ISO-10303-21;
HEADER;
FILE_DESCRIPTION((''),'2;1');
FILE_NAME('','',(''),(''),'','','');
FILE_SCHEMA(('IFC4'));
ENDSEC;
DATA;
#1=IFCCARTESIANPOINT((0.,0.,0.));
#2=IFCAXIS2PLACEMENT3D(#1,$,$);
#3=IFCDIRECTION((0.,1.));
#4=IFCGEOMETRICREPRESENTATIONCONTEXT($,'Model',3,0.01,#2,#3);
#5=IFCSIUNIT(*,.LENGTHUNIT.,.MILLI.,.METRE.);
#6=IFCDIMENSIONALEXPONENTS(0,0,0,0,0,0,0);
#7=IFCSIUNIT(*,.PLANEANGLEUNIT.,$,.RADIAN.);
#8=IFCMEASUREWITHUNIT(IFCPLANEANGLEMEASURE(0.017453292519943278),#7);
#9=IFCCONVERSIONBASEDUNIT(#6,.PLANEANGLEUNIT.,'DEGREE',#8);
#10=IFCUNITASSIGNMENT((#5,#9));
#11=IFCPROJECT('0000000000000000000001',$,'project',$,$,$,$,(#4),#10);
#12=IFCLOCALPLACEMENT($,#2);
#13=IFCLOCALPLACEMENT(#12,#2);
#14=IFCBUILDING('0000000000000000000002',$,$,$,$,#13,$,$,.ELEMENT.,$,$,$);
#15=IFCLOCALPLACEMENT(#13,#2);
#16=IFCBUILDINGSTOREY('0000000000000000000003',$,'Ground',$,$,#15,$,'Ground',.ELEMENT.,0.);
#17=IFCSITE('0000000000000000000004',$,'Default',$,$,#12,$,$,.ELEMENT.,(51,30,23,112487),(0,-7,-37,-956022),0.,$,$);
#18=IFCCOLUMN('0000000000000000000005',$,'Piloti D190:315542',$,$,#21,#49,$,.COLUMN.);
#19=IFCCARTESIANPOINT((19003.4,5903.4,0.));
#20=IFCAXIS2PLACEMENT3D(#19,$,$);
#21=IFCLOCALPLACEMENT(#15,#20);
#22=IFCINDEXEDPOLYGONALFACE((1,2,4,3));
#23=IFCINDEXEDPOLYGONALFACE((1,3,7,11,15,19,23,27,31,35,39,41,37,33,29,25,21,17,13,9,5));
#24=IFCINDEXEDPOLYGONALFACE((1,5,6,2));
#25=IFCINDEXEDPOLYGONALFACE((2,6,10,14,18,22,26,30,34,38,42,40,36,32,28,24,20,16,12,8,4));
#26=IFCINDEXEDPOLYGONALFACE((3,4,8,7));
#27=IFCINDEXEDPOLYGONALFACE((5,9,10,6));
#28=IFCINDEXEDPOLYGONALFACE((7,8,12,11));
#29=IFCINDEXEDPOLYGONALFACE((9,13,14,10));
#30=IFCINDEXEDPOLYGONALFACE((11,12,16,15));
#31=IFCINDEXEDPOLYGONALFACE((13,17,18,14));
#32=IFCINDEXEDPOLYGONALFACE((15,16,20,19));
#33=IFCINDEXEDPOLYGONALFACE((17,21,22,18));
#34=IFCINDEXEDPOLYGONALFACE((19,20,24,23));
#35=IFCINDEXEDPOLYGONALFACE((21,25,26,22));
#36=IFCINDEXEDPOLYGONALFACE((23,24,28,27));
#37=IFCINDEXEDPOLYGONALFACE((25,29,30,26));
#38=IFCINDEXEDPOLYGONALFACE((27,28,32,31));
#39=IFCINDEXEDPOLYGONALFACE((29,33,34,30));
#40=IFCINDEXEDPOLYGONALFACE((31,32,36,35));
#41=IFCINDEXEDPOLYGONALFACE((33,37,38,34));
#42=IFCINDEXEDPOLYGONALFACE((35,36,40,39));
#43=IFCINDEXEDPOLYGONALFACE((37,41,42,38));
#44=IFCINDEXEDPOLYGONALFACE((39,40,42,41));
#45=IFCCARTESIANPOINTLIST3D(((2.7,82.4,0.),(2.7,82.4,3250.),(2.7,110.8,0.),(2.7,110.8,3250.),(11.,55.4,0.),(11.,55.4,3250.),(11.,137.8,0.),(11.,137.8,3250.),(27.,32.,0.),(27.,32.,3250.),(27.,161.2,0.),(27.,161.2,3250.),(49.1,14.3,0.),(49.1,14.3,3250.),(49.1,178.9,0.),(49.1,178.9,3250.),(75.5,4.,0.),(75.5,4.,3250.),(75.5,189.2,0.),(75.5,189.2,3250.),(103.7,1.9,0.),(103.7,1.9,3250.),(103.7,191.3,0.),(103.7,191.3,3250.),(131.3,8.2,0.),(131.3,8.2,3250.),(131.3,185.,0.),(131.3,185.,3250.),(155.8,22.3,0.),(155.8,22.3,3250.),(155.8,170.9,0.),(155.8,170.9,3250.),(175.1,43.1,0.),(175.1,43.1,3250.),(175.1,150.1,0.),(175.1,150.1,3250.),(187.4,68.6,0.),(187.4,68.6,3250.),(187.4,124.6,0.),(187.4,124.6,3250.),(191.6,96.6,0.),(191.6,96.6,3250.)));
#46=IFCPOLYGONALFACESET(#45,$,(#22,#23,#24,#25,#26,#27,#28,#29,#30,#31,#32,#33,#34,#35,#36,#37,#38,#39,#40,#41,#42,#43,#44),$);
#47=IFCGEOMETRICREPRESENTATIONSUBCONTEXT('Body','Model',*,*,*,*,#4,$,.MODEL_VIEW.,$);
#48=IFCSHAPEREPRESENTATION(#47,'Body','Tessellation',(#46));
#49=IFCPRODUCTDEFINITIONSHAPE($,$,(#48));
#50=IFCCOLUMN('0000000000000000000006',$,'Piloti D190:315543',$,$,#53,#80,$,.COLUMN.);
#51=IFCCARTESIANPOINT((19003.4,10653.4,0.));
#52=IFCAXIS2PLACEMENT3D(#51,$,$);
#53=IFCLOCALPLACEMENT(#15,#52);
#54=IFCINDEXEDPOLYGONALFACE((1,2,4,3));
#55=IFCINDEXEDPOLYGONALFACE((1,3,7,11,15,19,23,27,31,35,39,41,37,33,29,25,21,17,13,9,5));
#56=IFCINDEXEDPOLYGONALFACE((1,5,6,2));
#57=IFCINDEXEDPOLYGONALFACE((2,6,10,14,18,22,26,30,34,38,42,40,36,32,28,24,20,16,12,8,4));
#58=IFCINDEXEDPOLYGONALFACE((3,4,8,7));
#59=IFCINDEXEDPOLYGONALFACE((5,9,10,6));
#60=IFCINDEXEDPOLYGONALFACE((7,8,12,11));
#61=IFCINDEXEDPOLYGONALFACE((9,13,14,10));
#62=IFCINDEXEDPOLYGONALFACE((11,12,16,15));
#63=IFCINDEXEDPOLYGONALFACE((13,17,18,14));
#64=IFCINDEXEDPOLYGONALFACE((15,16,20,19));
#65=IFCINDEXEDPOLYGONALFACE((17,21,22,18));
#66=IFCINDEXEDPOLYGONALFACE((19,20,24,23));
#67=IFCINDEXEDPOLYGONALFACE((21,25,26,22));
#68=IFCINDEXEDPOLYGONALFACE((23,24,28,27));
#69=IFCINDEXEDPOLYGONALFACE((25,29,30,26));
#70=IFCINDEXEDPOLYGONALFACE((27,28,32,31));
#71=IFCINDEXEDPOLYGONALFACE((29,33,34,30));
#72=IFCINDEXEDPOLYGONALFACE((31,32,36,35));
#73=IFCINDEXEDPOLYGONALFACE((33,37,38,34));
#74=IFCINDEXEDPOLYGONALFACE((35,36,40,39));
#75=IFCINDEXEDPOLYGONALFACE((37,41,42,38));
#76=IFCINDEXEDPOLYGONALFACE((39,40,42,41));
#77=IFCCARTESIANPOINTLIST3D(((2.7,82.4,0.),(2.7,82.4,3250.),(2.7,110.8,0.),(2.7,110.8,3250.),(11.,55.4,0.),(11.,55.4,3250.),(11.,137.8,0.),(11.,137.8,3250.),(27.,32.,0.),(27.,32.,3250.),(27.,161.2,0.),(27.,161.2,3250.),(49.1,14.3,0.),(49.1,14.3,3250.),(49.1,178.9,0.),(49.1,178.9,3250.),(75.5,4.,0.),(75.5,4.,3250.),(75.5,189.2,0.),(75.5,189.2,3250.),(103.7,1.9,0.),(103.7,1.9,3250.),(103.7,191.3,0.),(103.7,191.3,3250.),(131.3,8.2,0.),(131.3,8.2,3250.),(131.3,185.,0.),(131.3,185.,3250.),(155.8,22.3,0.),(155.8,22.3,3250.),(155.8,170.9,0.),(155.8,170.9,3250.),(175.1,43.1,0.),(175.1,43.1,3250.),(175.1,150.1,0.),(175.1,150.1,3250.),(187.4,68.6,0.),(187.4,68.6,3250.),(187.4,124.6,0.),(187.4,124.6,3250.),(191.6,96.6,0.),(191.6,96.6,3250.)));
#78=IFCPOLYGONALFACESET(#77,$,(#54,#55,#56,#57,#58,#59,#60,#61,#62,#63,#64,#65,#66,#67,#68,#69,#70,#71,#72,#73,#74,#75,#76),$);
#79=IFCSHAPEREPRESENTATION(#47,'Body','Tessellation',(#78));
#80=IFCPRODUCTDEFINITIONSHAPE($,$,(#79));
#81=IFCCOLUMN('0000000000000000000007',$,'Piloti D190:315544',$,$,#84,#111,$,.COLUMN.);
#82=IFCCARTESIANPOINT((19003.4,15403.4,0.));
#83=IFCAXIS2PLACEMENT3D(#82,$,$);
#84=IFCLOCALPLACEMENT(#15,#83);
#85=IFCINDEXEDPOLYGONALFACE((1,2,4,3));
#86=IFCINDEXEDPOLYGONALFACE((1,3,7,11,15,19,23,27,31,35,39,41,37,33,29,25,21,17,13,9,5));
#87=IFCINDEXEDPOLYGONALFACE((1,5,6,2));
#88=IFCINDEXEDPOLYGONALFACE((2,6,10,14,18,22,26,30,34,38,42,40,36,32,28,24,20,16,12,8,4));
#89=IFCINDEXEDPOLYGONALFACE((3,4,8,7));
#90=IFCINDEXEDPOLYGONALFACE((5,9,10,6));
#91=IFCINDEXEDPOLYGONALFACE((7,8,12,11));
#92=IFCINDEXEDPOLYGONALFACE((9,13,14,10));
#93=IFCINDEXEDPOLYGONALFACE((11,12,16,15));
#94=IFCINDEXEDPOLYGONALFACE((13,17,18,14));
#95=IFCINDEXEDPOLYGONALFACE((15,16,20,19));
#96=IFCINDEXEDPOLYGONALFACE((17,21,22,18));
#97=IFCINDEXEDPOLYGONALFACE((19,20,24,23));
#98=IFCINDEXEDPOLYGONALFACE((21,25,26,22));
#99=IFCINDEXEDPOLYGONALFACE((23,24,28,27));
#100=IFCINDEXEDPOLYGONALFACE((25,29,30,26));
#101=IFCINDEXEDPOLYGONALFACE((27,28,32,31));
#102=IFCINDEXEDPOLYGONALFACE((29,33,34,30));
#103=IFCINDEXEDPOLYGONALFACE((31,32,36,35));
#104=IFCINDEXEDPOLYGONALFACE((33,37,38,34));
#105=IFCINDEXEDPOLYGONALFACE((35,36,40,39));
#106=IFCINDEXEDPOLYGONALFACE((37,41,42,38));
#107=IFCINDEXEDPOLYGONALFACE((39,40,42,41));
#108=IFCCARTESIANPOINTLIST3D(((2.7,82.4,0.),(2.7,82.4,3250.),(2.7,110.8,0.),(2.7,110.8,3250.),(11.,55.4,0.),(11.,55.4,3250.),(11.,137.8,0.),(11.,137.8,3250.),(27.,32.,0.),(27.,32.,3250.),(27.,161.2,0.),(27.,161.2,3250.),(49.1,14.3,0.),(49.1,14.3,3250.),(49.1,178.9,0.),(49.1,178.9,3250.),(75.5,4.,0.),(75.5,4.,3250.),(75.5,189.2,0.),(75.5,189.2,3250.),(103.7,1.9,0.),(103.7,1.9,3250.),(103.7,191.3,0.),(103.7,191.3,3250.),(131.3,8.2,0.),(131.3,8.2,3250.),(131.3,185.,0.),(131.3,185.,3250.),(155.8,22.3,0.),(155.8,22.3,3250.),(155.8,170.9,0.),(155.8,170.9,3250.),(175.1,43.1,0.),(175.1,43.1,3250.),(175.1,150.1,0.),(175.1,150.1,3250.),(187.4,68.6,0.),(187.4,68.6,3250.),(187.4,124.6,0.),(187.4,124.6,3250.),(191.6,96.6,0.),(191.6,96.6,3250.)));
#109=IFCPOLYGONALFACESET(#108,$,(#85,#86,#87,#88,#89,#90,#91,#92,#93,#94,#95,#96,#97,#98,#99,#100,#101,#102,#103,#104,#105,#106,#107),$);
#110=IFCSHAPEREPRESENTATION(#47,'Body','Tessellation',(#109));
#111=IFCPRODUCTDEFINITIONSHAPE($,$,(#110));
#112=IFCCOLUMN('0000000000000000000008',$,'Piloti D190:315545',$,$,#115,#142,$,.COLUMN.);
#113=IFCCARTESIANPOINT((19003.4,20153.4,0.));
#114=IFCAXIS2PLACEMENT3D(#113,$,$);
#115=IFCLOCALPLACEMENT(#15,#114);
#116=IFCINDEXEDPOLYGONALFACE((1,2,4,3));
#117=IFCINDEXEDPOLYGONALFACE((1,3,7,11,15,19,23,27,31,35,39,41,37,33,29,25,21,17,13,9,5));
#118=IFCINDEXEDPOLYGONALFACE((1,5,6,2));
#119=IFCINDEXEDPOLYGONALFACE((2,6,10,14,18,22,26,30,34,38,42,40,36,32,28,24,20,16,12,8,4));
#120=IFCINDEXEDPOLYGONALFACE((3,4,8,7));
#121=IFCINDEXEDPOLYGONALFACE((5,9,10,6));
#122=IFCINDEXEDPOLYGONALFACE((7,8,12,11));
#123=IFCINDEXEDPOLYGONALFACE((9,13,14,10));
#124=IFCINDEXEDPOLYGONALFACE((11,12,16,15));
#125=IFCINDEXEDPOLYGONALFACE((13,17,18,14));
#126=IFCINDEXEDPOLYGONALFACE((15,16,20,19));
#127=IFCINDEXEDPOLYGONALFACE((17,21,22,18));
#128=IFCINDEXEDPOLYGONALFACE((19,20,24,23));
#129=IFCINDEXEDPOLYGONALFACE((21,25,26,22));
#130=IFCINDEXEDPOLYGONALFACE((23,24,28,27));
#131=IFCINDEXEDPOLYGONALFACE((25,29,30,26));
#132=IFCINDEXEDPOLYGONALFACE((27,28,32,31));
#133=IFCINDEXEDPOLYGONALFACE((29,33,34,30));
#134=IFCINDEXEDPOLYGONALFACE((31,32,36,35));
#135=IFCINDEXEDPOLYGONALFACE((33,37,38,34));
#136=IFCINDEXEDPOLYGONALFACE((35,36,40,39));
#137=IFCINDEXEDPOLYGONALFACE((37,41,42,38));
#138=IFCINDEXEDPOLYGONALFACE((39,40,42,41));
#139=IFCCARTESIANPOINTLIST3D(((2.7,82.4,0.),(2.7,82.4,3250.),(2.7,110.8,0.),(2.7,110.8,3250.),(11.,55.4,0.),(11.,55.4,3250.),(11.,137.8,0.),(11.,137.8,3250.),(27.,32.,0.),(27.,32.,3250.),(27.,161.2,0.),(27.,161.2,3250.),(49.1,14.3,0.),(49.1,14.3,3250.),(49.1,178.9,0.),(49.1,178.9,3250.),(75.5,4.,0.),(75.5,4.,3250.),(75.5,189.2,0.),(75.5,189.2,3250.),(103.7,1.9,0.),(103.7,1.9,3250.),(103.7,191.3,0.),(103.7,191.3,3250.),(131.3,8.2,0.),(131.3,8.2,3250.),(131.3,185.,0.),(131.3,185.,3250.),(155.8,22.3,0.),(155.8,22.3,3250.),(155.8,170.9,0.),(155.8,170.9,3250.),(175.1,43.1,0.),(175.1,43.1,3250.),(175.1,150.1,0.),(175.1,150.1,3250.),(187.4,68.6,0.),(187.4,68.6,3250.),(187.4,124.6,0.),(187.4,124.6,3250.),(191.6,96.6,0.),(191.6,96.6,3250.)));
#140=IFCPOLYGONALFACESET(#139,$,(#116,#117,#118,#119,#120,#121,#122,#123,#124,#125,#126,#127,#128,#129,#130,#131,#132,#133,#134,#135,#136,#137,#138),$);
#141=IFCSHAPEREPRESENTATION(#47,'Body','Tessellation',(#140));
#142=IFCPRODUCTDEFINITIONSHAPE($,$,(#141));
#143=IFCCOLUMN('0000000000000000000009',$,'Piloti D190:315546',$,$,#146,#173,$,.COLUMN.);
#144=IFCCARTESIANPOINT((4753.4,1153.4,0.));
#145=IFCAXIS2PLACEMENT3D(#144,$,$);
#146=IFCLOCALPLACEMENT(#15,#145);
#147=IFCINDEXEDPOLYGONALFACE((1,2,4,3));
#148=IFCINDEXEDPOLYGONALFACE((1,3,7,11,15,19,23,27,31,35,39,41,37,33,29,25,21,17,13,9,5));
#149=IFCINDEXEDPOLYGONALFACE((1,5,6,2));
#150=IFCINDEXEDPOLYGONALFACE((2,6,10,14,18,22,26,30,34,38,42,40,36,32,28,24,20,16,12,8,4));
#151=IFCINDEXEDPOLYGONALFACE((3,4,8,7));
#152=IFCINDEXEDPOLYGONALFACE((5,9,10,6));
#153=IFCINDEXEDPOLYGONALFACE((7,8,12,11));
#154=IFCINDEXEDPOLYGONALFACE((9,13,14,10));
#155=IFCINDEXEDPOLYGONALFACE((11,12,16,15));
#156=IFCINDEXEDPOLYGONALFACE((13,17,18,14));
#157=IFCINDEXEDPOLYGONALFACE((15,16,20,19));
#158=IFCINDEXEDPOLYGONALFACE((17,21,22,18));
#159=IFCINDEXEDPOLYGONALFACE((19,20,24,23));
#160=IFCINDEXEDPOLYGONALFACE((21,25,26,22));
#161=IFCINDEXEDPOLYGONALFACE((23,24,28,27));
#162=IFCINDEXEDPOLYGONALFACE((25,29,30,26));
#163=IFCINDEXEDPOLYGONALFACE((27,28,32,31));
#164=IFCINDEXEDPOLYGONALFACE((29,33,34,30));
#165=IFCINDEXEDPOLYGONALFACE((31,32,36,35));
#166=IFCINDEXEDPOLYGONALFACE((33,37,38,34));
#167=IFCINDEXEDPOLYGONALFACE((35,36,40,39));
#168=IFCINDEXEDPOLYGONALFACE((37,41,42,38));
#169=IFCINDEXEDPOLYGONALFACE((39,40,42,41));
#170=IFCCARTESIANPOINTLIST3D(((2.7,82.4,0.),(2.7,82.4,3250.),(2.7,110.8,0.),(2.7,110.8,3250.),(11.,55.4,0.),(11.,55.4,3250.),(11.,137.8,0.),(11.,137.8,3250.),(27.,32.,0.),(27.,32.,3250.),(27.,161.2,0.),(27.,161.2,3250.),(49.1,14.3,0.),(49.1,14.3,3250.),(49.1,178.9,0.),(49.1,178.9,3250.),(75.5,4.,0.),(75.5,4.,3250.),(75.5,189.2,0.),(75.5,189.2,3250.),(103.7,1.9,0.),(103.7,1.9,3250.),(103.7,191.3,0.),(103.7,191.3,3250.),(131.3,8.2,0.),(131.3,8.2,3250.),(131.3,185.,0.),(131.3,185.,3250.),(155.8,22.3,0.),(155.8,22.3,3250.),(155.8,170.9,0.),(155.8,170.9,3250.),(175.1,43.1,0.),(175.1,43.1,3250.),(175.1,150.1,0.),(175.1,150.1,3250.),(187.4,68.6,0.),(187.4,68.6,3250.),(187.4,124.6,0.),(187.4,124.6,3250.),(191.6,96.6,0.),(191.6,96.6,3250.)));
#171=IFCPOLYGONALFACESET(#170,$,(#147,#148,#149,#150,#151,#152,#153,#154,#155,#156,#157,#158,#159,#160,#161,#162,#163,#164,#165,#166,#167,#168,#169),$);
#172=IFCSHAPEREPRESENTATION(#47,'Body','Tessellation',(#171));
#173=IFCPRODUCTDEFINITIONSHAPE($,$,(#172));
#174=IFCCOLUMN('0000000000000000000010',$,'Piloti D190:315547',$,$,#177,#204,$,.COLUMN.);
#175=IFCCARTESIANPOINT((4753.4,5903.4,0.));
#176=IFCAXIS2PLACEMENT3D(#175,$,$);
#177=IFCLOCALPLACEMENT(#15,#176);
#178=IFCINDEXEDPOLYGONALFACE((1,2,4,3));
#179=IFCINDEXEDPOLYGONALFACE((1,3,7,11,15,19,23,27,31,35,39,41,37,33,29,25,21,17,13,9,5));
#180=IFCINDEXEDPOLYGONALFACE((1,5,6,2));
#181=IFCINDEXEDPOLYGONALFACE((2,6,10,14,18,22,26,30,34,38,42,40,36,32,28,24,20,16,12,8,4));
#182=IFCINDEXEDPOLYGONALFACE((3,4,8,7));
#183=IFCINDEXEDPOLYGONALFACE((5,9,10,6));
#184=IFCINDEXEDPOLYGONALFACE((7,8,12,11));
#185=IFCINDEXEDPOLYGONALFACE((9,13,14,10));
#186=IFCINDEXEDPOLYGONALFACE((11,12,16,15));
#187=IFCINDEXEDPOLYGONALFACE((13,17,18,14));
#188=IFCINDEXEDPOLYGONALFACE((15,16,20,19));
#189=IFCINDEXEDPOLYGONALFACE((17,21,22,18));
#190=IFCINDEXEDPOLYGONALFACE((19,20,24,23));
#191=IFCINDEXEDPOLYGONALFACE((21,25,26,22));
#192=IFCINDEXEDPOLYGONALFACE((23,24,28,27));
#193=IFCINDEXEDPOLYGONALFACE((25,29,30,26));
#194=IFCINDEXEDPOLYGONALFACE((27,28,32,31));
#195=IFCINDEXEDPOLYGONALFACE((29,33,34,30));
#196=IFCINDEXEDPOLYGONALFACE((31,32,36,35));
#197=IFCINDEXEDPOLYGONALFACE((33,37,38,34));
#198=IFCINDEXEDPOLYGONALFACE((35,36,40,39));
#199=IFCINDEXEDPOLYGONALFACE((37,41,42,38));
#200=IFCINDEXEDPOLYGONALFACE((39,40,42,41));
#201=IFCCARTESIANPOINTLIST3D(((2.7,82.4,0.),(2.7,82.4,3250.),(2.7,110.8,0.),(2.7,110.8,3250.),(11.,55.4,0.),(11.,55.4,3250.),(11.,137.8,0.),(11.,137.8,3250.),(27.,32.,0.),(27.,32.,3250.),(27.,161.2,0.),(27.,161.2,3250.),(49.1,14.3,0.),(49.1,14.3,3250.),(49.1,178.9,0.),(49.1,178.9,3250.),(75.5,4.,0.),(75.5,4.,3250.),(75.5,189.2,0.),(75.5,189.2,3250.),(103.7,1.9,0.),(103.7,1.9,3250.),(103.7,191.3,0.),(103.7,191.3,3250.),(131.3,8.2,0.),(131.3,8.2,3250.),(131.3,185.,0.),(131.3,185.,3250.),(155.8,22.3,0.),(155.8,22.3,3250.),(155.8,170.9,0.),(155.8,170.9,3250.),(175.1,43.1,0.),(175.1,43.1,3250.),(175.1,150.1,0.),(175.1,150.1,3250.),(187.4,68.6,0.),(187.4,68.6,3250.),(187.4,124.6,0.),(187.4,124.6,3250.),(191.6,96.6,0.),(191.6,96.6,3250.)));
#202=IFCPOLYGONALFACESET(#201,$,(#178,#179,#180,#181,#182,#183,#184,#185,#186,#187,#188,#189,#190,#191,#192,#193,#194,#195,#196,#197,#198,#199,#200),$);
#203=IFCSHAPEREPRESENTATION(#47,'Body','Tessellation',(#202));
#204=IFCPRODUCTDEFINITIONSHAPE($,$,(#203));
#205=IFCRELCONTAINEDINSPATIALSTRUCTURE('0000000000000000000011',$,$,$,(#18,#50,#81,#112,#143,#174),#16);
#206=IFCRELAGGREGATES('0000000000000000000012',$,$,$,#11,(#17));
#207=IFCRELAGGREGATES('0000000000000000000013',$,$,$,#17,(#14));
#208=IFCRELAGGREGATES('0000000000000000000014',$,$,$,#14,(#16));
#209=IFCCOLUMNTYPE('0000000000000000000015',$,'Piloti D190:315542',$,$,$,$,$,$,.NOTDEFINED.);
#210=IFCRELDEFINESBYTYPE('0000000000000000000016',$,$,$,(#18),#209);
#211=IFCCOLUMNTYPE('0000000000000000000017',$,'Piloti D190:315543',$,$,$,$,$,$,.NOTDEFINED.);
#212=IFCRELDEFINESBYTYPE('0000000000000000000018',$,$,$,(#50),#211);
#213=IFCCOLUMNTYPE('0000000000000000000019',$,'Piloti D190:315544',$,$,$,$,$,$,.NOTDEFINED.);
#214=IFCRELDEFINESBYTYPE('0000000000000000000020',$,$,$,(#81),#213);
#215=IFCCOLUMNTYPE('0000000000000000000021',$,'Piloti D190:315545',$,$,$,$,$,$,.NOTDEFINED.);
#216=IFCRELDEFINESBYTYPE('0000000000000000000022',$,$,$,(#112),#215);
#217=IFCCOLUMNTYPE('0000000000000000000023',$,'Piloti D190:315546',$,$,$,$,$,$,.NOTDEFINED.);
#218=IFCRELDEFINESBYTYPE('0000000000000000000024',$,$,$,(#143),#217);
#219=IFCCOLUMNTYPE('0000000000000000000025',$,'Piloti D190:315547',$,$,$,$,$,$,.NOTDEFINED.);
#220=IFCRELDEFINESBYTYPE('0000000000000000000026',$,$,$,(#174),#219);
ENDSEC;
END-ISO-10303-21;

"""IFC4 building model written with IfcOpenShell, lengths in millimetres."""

from ifc_helpers import new_model, entity, si_unit, converted_unit, direction, frame, origin, origin_2d_with_axis, place, context, subcontext, project, spatial, circle, extrude, type_object, element, save


model = new_model("IFC4")

# Units and contexts
model_context = context("Model", 3, precision=0.01, world=origin(), true_north=direction((0.0, 1.0)))
body_context = subcontext(model_context, "Body", "Model", "MODEL_VIEW")
ifc_project = project(units=[si_unit("LENGTHUNIT", "METRE", prefix="MILLI"), converted_unit("PLANEANGLEUNIT", "DEGREE", entity("IfcPlaneAngleMeasure", 0.017453292519943278), si_unit("PLANEANGLEUNIT", "RADIAN"), dimensions=[0, 0, 0, 0, 0, 0, 0])], contexts=[model_context])

# Site, building, storey
site_placement = place(None, origin())
site = spatial("IfcSite", under=ifc_project, at=site_placement, Name="Default", CompositionType="ELEMENT", RefLatitude=(51, 30, 23, 112487), RefLongitude=(0, -7, -37, -956022), RefElevation=0.0)
building_placement = place(site_placement, origin())
building = spatial("IfcBuilding", under=site, at=building_placement, CompositionType="ELEMENT")
storey_placement = place(building_placement, origin())
storey = spatial("IfcBuildingStorey", under=building, at=storey_placement, Name="Ground", LongName="Ground", CompositionType="ELEMENT", Elevation=0.0)

# Columns
column_type_1 = type_object("IfcColumnType", Name="Piloti D190:315542", PredefinedType="NOTDEFINED")
column_1_placement = place(storey_placement, frame((19003.4, 5903.4, 0.0)))
element("IfcColumn", 1, at=column_1_placement, inside=storey, type_object=column_type_1, Name="Piloti D190:315542", PredefinedType="COLUMN", context=body_context, shape_type="SweptSolid", body=[
    extrude(circle(Radius=95.0, at=origin_2d_with_axis()), frame((96.6, 96.6, 0.0)), (0.0, 0.0, 1.0), 3250.0),
])
column_type_2 = type_object("IfcColumnType", Name="Piloti D190:315543", PredefinedType="NOTDEFINED")
column_2_placement = place(storey_placement, frame((19003.4, 10653.4, 0.0)))
element("IfcColumn", 2, at=column_2_placement, inside=storey, type_object=column_type_2, Name="Piloti D190:315543", PredefinedType="COLUMN", context=body_context, shape_type="SweptSolid", body=[
    extrude(circle(Radius=95.0, at=origin_2d_with_axis()), frame((96.6, 96.6, 0.0)), (0.0, 0.0, 1.0), 3250.0),
])
column_type_3 = type_object("IfcColumnType", Name="Piloti D190:315544", PredefinedType="NOTDEFINED")
column_3_placement = place(storey_placement, frame((19003.4, 15403.4, 0.0)))
element("IfcColumn", 3, at=column_3_placement, inside=storey, type_object=column_type_3, Name="Piloti D190:315544", PredefinedType="COLUMN", context=body_context, shape_type="SweptSolid", body=[
    extrude(circle(Radius=95.0, at=origin_2d_with_axis()), frame((96.6, 96.6, 0.0)), (0.0, 0.0, 1.0), 3250.0),
])
column_type_4 = type_object("IfcColumnType", Name="Piloti D190:315545", PredefinedType="NOTDEFINED")
column_4_placement = place(storey_placement, frame((19003.4, 20153.4, 0.0)))
element("IfcColumn", 4, at=column_4_placement, inside=storey, type_object=column_type_4, Name="Piloti D190:315545", PredefinedType="COLUMN", context=body_context, shape_type="SweptSolid", body=[
    extrude(circle(Radius=95.0, at=origin_2d_with_axis()), frame((96.6, 96.6, 0.0)), (0.0, 0.0, 1.0), 3250.0),
])
column_type_5 = type_object("IfcColumnType", Name="Piloti D190:315546", PredefinedType="NOTDEFINED")
column_5_placement = place(storey_placement, frame((4753.4, 1153.4, 0.0)))
element("IfcColumn", 5, at=column_5_placement, inside=storey, type_object=column_type_5, Name="Piloti D190:315546", PredefinedType="COLUMN", context=body_context, shape_type="SweptSolid", body=[
    extrude(circle(Radius=95.0, at=origin_2d_with_axis()), frame((96.6, 96.6, 0.0)), (0.0, 0.0, 1.0), 3250.0),
])
column_type_6 = type_object("IfcColumnType", Name="Piloti D190:315547", PredefinedType="NOTDEFINED")
column_6_placement = place(storey_placement, frame((4753.4, 5903.4, 0.0)))
element("IfcColumn", 6, at=column_6_placement, inside=storey, type_object=column_type_6, Name="Piloti D190:315547", PredefinedType="COLUMN", context=body_context, shape_type="SweptSolid", body=[
    extrude(circle(Radius=95.0, at=origin_2d_with_axis()), frame((96.6, 96.6, 0.0)), (0.0, 0.0, 1.0), 3250.0),
])

save(model, "model.ifc")
